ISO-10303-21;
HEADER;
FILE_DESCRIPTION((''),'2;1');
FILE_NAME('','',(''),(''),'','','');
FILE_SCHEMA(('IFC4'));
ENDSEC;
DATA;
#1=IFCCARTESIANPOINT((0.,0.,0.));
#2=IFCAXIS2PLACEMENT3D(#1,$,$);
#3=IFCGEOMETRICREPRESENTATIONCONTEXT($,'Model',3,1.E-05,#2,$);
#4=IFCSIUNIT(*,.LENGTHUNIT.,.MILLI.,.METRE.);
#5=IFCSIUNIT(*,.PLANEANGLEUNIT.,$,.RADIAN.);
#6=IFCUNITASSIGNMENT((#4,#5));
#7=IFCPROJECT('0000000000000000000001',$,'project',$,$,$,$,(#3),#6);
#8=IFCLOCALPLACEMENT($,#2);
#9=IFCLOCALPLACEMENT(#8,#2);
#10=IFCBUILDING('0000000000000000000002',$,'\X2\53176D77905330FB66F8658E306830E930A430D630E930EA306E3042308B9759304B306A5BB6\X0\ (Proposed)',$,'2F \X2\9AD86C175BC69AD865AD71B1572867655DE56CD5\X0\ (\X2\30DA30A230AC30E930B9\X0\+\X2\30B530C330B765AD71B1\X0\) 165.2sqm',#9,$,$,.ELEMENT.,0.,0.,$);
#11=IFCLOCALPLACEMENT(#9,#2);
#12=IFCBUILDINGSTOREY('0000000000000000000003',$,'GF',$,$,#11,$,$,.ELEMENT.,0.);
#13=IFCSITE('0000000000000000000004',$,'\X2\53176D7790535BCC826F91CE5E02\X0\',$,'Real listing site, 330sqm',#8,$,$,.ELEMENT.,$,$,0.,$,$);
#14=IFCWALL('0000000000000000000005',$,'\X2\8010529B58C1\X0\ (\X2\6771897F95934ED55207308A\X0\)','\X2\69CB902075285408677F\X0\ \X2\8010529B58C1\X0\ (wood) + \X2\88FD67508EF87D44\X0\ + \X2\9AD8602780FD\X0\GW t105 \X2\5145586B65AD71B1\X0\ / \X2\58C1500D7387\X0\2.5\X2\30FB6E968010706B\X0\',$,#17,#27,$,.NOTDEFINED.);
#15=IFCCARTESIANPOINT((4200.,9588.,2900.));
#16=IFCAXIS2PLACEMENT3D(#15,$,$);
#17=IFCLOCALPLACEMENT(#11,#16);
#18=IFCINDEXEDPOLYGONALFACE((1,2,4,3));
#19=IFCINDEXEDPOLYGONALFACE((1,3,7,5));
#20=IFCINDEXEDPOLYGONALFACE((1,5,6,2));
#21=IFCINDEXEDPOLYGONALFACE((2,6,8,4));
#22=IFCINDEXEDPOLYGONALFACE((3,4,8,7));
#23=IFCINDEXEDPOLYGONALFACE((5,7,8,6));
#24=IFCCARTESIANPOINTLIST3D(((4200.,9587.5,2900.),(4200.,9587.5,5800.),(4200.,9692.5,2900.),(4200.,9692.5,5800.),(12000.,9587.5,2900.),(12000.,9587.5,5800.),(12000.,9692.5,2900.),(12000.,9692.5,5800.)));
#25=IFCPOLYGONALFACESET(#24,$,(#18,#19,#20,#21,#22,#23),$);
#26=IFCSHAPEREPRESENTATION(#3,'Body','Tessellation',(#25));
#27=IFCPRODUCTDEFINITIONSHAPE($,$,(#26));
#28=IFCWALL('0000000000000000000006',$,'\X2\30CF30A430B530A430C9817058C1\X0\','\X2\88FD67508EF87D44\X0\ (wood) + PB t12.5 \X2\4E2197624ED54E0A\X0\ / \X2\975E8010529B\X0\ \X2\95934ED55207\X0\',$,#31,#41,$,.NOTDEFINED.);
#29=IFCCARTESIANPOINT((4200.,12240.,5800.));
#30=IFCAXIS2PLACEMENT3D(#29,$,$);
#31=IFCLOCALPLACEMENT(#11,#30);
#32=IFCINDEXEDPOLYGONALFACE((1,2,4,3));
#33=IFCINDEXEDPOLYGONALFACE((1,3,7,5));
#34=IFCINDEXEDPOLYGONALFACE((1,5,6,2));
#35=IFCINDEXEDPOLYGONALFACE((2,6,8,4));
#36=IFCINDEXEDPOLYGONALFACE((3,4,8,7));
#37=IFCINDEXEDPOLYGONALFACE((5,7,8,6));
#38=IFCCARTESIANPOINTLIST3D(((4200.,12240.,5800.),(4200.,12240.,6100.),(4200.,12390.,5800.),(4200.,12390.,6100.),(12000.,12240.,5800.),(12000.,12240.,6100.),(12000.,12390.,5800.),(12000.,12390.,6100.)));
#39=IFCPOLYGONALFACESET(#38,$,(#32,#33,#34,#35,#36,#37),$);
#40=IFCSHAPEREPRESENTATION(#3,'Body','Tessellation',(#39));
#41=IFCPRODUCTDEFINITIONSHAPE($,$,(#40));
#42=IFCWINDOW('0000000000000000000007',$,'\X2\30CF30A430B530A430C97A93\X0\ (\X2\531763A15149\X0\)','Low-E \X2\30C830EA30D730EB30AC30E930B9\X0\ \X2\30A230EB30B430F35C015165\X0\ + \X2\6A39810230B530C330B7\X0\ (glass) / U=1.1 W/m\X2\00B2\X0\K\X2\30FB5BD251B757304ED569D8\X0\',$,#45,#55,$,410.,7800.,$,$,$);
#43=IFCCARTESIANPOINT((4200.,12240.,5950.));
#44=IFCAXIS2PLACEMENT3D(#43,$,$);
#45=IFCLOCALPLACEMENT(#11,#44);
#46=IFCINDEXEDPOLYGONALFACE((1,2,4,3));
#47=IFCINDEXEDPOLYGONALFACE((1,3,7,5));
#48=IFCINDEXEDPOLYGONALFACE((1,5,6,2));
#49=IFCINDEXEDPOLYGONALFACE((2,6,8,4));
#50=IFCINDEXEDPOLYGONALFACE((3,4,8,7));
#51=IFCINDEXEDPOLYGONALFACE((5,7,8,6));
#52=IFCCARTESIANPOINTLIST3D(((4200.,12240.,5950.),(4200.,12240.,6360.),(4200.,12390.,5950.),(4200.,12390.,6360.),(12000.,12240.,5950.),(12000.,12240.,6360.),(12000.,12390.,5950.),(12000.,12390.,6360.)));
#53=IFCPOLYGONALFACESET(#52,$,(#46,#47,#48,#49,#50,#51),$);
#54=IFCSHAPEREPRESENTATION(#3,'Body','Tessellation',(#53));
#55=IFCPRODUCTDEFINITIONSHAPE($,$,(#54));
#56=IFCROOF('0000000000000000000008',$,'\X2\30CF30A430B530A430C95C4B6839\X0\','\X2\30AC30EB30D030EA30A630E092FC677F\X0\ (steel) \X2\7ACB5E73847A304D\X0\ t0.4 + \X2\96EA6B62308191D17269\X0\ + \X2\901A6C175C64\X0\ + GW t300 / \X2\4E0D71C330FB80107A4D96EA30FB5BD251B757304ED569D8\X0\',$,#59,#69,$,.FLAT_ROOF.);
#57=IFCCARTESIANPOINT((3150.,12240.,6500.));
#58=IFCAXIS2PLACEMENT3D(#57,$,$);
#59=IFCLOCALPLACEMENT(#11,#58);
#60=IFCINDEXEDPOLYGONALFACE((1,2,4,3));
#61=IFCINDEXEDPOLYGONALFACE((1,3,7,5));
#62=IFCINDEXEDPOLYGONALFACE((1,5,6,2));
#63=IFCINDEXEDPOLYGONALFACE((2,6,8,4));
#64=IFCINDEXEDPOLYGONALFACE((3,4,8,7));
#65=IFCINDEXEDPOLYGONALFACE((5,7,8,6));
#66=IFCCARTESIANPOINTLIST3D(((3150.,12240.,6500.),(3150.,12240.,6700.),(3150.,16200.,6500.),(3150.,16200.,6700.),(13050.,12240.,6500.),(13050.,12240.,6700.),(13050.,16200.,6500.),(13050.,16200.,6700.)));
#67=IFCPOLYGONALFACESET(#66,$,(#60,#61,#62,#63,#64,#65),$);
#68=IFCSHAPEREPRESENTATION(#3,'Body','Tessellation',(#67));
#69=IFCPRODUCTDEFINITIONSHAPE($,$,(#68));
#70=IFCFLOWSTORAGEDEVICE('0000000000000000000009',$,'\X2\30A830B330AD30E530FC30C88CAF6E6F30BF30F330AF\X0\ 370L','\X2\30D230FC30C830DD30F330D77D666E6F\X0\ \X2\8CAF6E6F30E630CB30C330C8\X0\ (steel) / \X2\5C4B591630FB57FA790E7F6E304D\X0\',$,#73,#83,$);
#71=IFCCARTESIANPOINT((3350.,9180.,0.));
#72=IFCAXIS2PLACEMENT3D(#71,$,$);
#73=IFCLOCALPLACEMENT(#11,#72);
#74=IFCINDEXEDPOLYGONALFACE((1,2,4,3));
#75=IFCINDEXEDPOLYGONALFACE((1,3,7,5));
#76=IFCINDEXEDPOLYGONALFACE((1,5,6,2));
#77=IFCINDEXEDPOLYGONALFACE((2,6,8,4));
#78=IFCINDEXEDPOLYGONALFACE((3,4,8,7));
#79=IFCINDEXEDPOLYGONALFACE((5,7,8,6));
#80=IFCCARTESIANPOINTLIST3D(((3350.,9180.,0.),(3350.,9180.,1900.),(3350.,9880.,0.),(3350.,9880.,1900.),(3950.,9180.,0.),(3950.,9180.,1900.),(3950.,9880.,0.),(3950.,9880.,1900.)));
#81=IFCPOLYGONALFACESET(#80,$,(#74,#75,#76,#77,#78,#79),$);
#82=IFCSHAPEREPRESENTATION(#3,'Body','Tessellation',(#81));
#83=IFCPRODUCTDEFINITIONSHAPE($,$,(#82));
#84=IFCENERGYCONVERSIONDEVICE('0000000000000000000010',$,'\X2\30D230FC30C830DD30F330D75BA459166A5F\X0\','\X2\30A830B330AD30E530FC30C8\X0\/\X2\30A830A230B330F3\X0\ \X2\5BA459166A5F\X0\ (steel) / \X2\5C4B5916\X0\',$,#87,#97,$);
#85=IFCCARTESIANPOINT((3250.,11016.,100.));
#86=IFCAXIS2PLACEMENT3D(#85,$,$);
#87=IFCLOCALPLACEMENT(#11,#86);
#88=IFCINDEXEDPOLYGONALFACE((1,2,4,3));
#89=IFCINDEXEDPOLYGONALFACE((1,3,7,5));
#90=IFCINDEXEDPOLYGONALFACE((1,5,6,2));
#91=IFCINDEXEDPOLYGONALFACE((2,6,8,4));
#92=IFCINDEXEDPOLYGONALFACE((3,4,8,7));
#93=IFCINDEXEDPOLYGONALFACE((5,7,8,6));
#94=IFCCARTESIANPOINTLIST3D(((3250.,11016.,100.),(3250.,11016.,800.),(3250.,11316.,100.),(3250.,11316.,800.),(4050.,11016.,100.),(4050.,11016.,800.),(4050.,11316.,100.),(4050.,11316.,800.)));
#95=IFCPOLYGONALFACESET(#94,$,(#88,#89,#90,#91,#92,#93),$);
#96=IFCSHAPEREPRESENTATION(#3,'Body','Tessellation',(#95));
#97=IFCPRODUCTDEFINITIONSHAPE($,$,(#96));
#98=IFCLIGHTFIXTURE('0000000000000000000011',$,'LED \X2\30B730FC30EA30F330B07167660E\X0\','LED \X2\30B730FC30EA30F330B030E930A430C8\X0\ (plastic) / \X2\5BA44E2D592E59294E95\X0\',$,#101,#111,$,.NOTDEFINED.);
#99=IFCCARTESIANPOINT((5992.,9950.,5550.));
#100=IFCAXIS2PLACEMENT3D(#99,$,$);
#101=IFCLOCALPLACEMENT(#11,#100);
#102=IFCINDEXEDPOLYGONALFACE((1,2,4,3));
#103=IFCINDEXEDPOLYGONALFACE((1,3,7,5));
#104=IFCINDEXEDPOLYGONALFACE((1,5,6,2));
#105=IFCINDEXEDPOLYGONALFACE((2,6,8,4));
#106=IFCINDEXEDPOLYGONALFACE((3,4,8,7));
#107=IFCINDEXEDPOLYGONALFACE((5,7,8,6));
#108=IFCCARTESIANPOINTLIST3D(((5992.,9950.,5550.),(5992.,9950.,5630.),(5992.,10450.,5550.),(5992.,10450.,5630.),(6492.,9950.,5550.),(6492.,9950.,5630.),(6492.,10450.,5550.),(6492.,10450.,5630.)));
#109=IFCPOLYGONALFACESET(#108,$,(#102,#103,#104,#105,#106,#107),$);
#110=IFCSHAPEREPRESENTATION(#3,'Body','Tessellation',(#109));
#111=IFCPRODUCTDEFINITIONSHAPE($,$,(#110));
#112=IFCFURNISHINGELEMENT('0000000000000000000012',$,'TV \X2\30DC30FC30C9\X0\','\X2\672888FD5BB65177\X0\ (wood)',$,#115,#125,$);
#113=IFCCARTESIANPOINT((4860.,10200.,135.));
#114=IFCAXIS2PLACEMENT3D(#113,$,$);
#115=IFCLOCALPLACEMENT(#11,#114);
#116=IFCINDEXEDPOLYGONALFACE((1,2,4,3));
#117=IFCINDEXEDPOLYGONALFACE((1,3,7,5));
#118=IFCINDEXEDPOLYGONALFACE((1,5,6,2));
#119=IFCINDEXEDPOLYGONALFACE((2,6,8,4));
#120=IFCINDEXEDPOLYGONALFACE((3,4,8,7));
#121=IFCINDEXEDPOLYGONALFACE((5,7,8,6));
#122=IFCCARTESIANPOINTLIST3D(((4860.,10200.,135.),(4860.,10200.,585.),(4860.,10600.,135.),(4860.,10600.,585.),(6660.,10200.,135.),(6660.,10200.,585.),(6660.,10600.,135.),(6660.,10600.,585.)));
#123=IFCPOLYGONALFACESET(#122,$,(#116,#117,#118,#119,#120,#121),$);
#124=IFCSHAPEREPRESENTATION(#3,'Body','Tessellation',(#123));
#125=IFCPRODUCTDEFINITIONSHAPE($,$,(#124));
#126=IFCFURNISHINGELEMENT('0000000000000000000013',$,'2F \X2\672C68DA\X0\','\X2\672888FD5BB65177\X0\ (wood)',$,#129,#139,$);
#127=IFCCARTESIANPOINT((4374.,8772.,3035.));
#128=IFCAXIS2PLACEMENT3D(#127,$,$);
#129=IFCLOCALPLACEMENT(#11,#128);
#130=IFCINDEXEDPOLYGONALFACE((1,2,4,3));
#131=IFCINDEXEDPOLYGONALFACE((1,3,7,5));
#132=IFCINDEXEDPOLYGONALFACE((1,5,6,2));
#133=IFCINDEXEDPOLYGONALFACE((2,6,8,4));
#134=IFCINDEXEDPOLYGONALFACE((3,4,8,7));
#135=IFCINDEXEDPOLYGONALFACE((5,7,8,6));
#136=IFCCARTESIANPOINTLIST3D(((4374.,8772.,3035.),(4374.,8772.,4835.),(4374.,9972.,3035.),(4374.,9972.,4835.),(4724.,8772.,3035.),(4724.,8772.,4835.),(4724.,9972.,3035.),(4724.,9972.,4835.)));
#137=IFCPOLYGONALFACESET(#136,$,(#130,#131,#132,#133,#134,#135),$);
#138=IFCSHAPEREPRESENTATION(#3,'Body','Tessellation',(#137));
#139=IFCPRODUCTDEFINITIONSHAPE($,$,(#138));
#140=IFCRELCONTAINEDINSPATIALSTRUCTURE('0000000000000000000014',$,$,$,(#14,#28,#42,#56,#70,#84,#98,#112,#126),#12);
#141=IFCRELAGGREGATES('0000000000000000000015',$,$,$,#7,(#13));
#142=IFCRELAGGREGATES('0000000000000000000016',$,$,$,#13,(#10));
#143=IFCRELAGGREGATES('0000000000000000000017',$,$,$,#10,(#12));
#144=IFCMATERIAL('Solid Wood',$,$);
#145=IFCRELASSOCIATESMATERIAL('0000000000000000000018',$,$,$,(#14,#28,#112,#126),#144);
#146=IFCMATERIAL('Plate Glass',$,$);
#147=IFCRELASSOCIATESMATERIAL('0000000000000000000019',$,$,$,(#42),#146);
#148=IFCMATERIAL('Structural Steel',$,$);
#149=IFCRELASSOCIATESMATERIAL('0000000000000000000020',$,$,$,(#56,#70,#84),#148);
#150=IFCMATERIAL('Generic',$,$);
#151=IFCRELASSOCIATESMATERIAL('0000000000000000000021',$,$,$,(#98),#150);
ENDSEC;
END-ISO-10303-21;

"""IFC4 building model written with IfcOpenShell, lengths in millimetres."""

from ifc_helpers import new_model, si_unit, frame, frame_2d, origin, place, context, project, spatial, rectangle, extrude, material, element, fill, save


model = new_model("IFC4")

# Units and contexts
model_context = context("Model", 3, precision=1e-05, world=origin())
ifc_project = project(units=[si_unit("LENGTHUNIT", "METRE", prefix="MILLI"), si_unit("PLANEANGLEUNIT", "RADIAN")], contexts=[model_context])

# Site, building, storey
site_placement = place(None, origin())
site = spatial("IfcSite", under=ifc_project, at=site_placement, Name="北海道富良野市", ObjectType="Real listing site, 330sqm", CompositionType="ELEMENT", RefElevation=0.0)
building_placement = place(site_placement, origin())
building = spatial("IfcBuilding", under=site, at=building_placement, Name="北海道・書斎とライブラリのある静かな家 (Proposed)", ObjectType="2F 高気密高断熱在来工法 (ペアガラス+サッシ断熱) 165.2sqm", CompositionType="ELEMENT", ElevationOfRefHeight=0.0, ElevationOfTerrain=0.0)
storey_placement = place(building_placement, origin())
storey = spatial("IfcBuildingStorey", under=building, at=storey_placement, Name="GF", CompositionType="ELEMENT", Elevation=0.0)

# Shared definitions
ifc_material_1 = material(Name="Solid Wood")

# Wall
wall_1_placement = place(storey_placement, frame((4200.0, 9588.0, 2900.0)))
element("IfcWall", 1, at=wall_1_placement, inside=storey, material=ifc_material_1, Name="耐力壁 (東西間仕切り)", Description="構造用合板 耐力壁 (wood) + 製材軸組 + 高性能GW t105 充填断熱 / 壁倍率2.5・準耐火", PredefinedType="NOTDEFINED", context=model_context, shape_type="SweptSolid", body=[
    extrude(rectangle(XDim=7800.0, YDim=105.0, at=frame_2d((3900.0, 52.0))), frame((4200.0, 9588.0, 2900.0)), (0.0, 0.0, 1.0), 2900.0),
])

# Wall, opening, window
wall_2_placement = place(storey_placement, frame((4200.0, 12240.0, 5800.0)))
wall_2 = element("IfcWall", 2, at=wall_2_placement, inside=storey, material=ifc_material_1, Name="ハイサイド腰壁", Description="製材軸組 (wood) + PB t12.5 両面仕上 / 非耐力 間仕切", PredefinedType="NOTDEFINED", context=model_context, shape_type="SweptSolid", body=[
    extrude(rectangle(XDim=7800.0, YDim=150.0, at=frame_2d((3900.0, 75.0))), frame((4200.0, 12240.0, 5800.0)), (0.0, 0.0, 1.0), 700.0),
])
opening_1_placement = place(storey_placement, frame((4200.0, 12240.0, 5950.0)))
opening_1 = element("IfcOpeningElement", 3, at=opening_1_placement, cuts=wall_2, PredefinedType="NOTDEFINED", context=model_context, shape_type="SweptSolid", body=[
    extrude(rectangle(XDim=7800.0, YDim=150.0, at=frame_2d((3900.0, 75.0))), frame((4200.0, 12240.0, 5950.0)), (0.0, 0.0, 1.0), 410.0),
])
ifc_material_2 = material(Name="Plate Glass")
window_placement = place(storey_placement, frame((4200.0, 12240.0, 5950.0)))
window = element("IfcWindow", 4, at=window_placement, inside=storey, material=ifc_material_2, Name="ハイサイド窓 (北採光)", Description="Low-E トリプルガラス アルゴン封入 + 樹脂サッシ (glass) / U=1.1 W/m²K・寒冷地仕様", OverallHeight=410.0, OverallWidth=7800.0, context=model_context, shape_type="SweptSolid", body=[
    extrude(rectangle(XDim=7800.0, YDim=150.0, at=frame_2d((3900.0, 75.0))), frame((4200.0, 12240.0, 5950.0)), (0.0, 0.0, 1.0), 410.0),
])
fill(opening_1, window)

# Roof
ifc_material_3 = material(Name="Structural Steel")
roof_placement = place(storey_placement, frame((3150.0, 12240.0, 6500.0)))
element("IfcRoof", 5, at=roof_placement, inside=storey, material=ifc_material_3, Name="ハイサイド屋根", Description="ガルバリウム鋼板 (steel) 立平葺き t0.4 + 雪止め金物 + 通気層 + GW t300 / 不燃・耐積雪・寒冷地仕様", PredefinedType="FLAT_ROOF", context=model_context, shape_type="SweptSolid", body=[
    extrude(rectangle(XDim=9900.0, YDim=3960.0, at=frame_2d((4950.0, 1980.0))), frame((3150.0, 12240.0, 6500.0)), (0.0, 0.0, 1.0), 200.0),
])

# Flow storage device
flow_storage_device_placement = place(storey_placement, frame((3350.0, 9180.0, 0.0)))
element("IfcFlowStorageDevice", 6, at=flow_storage_device_placement, inside=storey, material=ifc_material_3, Name="エコキュート貯湯タンク 370L", Description="ヒートポンプ給湯 貯湯ユニット (steel) / 屋外・基礎置き", context=model_context, shape_type="SweptSolid", body=[
    extrude(rectangle(XDim=600.0, YDim=700.0, at=frame_2d((300.0, 350.0))), frame((3350.0, 9180.0, 0.0)), (0.0, 0.0, 1.0), 1900.0),
])

# Energy conversion device
energy_conversion_device_placement = place(storey_placement, frame((3250.0, 11016.0, 100.0)))
element("IfcEnergyConversionDevice", 7, at=energy_conversion_device_placement, inside=storey, material=ifc_material_3, Name="ヒートポンプ室外機", Description="エコキュート/エアコン 室外機 (steel) / 屋外", context=model_context, shape_type="SweptSolid", body=[
    extrude(rectangle(XDim=800.0, YDim=300.0, at=frame_2d((400.0, 150.0))), frame((3250.0, 11016.0, 100.0)), (0.0, 0.0, 1.0), 700.0),
])

# Light fixture
ifc_material_4 = material(Name="Generic")
light_fixture_placement = place(storey_placement, frame((5992.0, 9950.0, 5550.0)))
element("IfcLightFixture", 8, at=light_fixture_placement, inside=storey, material=ifc_material_4, Name="LED シーリング照明", Description="LED シーリングライト (plastic) / 室中央天井", PredefinedType="NOTDEFINED", context=model_context, shape_type="SweptSolid", body=[
    extrude(rectangle(XDim=500.0, YDim=500.0, at=frame_2d((250.0, 250.0))), frame((5992.0, 9950.0, 5550.0)), (0.0, 0.0, 1.0), 80.0),
])

# Furnishing elements
furnishing_1_placement = place(storey_placement, frame((4860.0, 10200.0, 135.0)))
element("IfcFurnishingElement", 9, at=furnishing_1_placement, inside=storey, material=ifc_material_1, Name="TV ボード", Description="木製家具 (wood)", context=model_context, shape_type="SweptSolid", body=[
    extrude(rectangle(XDim=1800.0, YDim=400.0, at=frame_2d((900.0, 200.0))), frame((4860.0, 10200.0, 135.0)), (0.0, 0.0, 1.0), 450.0),
])
furnishing_2_placement = place(storey_placement, frame((4374.0, 8772.0, 3035.0)))
element("IfcFurnishingElement", 10, at=furnishing_2_placement, inside=storey, material=ifc_material_1, Name="2F 本棚", Description="木製家具 (wood)", context=model_context, shape_type="SweptSolid", body=[
    extrude(rectangle(XDim=350.0, YDim=1200.0, at=frame_2d((175.0, 600.0))), frame((4374.0, 8772.0, 3035.0)), (0.0, 0.0, 1.0), 1800.0),
])

save(model, "model.ifc")
